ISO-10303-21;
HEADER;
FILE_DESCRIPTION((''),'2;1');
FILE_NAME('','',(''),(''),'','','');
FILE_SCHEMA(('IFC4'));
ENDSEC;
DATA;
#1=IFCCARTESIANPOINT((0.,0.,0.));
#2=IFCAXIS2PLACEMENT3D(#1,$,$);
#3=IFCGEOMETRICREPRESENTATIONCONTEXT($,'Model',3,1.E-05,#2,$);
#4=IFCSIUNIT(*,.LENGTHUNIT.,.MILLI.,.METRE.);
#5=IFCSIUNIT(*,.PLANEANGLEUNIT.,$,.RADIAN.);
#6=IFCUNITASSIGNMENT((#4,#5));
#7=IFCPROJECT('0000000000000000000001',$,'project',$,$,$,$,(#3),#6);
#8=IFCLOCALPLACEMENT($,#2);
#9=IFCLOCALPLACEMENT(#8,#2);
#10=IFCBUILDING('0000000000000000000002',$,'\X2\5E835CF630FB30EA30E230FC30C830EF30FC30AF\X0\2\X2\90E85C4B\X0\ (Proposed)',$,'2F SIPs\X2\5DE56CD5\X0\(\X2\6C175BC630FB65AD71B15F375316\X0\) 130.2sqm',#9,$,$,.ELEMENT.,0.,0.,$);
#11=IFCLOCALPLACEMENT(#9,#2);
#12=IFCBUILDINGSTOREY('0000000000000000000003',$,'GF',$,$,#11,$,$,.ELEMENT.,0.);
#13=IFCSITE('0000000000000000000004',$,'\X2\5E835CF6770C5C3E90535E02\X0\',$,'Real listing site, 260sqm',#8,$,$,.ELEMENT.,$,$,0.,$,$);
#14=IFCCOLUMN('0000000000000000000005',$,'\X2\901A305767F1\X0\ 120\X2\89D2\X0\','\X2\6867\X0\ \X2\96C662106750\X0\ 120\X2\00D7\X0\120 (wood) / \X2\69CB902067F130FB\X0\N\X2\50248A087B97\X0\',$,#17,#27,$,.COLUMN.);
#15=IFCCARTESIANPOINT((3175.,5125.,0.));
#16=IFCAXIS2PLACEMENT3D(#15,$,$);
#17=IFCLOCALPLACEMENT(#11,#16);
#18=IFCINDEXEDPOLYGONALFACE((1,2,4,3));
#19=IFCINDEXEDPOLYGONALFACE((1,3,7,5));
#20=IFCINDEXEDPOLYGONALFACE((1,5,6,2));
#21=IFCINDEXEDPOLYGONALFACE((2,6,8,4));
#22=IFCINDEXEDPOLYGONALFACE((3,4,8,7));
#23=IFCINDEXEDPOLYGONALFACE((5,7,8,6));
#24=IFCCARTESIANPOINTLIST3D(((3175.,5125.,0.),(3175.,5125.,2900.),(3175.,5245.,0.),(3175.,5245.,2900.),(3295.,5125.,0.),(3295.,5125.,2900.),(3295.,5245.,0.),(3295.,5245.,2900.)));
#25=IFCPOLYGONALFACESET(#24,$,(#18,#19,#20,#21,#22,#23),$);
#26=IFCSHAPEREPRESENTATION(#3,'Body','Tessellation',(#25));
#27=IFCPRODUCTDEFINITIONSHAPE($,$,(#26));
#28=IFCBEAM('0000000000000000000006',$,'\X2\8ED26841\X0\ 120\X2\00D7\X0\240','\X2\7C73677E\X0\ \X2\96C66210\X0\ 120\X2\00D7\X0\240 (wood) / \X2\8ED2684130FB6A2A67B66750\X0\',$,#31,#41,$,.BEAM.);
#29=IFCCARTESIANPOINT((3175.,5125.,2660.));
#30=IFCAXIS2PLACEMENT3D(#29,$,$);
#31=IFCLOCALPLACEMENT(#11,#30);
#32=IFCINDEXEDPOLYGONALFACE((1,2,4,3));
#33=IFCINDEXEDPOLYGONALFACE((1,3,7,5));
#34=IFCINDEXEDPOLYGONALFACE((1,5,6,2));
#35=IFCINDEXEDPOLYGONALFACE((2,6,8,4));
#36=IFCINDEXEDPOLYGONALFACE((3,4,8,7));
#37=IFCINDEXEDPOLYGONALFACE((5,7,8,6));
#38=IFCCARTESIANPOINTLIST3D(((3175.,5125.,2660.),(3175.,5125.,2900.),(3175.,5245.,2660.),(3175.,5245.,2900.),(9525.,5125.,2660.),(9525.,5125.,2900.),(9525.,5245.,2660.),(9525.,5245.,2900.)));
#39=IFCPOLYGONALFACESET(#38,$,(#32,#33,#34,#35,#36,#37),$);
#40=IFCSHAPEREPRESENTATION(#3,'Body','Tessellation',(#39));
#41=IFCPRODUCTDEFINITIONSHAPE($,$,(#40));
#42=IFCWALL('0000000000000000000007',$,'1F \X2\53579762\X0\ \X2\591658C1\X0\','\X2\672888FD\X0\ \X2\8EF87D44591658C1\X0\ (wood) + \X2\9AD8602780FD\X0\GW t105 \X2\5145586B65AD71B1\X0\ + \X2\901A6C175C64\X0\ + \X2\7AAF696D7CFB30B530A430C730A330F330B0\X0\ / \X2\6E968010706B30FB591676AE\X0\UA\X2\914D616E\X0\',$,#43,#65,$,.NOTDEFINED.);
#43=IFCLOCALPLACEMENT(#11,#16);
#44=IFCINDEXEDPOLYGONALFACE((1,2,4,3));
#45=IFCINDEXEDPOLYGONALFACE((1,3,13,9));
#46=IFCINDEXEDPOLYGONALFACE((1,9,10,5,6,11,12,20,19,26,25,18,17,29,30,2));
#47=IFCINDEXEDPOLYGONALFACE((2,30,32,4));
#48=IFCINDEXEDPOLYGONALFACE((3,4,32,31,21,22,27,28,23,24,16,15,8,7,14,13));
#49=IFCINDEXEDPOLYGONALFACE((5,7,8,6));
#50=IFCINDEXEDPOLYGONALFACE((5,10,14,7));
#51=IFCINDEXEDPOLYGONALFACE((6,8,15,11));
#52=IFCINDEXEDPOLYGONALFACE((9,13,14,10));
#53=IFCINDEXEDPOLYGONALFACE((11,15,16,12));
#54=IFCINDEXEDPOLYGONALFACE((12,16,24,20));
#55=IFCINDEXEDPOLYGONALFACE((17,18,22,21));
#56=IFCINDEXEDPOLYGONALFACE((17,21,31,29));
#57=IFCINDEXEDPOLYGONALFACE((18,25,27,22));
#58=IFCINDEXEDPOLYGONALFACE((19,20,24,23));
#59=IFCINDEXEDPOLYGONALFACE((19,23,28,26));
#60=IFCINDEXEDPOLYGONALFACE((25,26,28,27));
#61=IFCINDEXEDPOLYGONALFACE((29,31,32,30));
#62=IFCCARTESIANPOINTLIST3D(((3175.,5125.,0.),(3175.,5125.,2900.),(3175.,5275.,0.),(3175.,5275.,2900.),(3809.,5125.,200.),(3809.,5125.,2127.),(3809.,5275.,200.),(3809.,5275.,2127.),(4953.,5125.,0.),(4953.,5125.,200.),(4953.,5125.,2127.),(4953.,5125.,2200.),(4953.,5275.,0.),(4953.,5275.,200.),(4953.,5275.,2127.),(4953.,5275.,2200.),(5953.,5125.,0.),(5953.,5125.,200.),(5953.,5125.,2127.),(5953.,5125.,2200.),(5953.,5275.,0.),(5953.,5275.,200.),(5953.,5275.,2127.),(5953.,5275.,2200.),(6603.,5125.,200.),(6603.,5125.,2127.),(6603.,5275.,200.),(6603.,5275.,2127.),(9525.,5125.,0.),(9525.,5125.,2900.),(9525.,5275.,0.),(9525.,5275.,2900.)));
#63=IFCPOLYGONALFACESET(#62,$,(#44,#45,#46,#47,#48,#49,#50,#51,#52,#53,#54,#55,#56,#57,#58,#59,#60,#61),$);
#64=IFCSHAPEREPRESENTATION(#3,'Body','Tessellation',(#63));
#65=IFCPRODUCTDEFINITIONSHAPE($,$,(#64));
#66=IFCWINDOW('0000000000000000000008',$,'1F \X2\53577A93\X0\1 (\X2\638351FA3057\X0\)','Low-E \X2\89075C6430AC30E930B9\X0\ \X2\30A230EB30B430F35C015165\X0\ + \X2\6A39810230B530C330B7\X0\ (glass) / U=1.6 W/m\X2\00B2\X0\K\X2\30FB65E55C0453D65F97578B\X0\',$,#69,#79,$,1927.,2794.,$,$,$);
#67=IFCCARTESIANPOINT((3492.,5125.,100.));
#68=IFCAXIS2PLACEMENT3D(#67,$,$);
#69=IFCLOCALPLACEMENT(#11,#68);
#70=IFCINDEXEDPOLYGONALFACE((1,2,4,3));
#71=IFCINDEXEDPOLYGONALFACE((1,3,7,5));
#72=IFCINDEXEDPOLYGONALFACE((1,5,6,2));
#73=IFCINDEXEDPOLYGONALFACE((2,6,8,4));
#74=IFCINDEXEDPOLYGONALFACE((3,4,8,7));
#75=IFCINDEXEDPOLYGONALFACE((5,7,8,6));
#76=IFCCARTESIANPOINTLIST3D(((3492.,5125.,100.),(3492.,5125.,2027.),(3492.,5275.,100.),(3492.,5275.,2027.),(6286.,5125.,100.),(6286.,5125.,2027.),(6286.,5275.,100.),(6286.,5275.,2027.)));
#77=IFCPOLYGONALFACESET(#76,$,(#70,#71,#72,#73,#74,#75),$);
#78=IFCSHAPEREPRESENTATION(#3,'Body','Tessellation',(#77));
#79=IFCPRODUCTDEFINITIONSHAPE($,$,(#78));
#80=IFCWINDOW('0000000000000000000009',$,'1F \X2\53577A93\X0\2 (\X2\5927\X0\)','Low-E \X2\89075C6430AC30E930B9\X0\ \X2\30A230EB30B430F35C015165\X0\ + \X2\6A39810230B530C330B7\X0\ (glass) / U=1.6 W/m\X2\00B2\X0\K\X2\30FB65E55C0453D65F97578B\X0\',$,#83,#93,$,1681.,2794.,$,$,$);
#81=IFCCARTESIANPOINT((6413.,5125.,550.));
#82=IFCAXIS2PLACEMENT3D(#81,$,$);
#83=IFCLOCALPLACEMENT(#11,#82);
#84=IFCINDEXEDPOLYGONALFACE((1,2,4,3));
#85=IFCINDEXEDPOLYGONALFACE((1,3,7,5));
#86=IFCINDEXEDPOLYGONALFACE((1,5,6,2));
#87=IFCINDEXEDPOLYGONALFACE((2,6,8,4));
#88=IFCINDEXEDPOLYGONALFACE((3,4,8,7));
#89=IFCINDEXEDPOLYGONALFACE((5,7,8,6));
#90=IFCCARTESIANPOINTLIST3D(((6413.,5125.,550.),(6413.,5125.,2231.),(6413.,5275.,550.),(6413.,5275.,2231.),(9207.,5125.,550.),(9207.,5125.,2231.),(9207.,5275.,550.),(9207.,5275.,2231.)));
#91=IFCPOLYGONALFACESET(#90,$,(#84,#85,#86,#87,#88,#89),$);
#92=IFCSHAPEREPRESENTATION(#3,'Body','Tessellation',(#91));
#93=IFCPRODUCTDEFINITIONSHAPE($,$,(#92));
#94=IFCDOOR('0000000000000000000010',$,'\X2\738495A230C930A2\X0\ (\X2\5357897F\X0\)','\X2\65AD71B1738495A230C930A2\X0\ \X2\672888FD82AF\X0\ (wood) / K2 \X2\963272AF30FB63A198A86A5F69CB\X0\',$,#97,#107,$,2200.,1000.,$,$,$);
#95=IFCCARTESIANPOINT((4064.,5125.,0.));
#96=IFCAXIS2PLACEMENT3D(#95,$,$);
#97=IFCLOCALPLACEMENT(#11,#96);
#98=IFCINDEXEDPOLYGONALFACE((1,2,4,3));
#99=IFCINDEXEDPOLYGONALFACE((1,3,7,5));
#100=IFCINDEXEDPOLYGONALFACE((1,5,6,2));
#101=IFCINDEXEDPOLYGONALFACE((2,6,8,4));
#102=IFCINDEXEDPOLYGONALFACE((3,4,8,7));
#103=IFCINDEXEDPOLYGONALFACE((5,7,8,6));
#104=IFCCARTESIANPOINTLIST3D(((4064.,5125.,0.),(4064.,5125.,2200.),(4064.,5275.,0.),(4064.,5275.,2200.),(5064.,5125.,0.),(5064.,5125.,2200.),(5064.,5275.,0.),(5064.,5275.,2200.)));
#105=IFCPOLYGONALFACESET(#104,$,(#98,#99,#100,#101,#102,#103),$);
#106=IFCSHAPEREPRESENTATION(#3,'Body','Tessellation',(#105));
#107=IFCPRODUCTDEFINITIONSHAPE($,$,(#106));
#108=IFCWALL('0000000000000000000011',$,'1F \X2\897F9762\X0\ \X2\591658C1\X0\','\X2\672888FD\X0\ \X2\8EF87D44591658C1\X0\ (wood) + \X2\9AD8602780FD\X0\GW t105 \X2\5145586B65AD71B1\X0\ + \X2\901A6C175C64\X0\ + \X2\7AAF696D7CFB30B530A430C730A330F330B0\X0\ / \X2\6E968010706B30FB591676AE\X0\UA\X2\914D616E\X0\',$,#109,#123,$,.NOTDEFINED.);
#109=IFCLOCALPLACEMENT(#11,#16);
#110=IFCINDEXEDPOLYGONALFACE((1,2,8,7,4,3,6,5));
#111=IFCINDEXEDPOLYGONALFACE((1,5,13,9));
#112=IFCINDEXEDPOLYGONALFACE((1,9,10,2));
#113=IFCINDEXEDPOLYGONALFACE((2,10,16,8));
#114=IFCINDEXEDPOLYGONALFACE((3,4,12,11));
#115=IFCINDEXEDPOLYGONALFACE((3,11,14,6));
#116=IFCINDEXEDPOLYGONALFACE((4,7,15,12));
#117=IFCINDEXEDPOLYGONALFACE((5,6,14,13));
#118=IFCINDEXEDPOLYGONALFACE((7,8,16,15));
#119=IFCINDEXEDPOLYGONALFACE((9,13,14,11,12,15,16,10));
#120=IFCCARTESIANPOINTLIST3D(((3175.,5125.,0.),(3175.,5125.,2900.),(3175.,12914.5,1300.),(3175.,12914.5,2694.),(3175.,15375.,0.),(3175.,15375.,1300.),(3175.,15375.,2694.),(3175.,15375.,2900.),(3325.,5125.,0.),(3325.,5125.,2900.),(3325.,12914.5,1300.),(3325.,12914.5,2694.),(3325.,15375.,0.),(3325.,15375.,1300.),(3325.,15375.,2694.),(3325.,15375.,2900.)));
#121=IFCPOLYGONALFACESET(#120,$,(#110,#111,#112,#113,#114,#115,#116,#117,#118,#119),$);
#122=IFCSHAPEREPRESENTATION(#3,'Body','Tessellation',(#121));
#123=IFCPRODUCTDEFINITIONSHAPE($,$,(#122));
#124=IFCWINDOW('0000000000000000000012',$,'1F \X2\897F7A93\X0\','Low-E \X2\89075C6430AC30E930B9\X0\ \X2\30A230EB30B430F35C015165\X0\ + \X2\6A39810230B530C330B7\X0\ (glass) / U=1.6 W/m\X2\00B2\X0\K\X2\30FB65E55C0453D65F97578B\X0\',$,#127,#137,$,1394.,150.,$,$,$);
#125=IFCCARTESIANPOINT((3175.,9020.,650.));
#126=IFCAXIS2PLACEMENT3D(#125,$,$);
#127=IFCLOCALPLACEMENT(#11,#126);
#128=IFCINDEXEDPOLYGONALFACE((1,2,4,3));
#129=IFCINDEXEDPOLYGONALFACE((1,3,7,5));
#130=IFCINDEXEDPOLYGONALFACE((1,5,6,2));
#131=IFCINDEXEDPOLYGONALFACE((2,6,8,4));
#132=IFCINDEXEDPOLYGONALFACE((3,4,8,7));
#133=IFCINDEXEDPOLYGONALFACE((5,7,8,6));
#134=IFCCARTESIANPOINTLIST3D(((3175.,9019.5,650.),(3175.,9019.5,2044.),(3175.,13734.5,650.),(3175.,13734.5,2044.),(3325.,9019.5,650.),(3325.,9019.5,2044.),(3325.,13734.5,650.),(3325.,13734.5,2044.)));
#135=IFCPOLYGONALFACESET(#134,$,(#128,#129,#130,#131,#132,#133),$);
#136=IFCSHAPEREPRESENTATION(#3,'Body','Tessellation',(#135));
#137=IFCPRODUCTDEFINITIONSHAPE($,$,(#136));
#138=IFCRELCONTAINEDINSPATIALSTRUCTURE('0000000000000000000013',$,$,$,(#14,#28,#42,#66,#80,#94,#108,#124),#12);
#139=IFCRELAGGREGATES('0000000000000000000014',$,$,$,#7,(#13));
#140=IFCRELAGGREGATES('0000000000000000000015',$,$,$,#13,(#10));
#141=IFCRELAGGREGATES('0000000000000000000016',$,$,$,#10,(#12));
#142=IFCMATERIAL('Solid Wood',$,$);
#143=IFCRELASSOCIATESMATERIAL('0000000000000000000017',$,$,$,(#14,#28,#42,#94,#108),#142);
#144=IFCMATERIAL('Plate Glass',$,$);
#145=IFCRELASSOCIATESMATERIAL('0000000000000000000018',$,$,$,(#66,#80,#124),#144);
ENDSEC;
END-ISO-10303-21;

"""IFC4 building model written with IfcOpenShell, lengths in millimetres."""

from ifc_helpers import new_model, si_unit, frame, frame_2d, origin, place, context, project, spatial, rectangle, extrude, material, element, fill, save


model = new_model("IFC4")

# Units and contexts
model_context = context("Model", 3, precision=1e-05, world=origin())
ifc_project = project(units=[si_unit("LENGTHUNIT", "METRE", prefix="MILLI"), si_unit("PLANEANGLEUNIT", "RADIAN")], contexts=[model_context])

# Site, building, storey
site_placement = place(None, origin())
site = spatial("IfcSite", under=ifc_project, at=site_placement, Name="広島県尾道市", ObjectType="Real listing site, 260sqm", CompositionType="ELEMENT", RefElevation=0.0)
building_placement = place(site_placement, origin())
building = spatial("IfcBuilding", under=site, at=building_placement, Name="広島・リモートワーク2部屋 (Proposed)", ObjectType="2F SIPs工法(気密・断熱強化) 130.2sqm", CompositionType="ELEMENT", ElevationOfRefHeight=0.0, ElevationOfTerrain=0.0)
storey_placement = place(building_placement, origin())
storey = spatial("IfcBuildingStorey", under=building, at=storey_placement, Name="GF", CompositionType="ELEMENT", Elevation=0.0)

# Column
ifc_material_1 = material(Name="Solid Wood")
column_placement = place(storey_placement, frame((3175.0, 5125.0, 0.0)))
element("IfcColumn", 1, at=column_placement, inside=storey, material=ifc_material_1, Name="通し柱 120角", Description="桧 集成材 120×120 (wood) / 構造柱・N値計算", PredefinedType="COLUMN", context=model_context, shape_type="SweptSolid", body=[
    extrude(rectangle(XDim=120.0, YDim=120.0, at=frame_2d((60.0, 60.0))), frame((3175.0, 5125.0, 0.0)), (0.0, 0.0, 1.0), 2900.0),
])

# Beam
beam_1_placement = place(storey_placement, frame((3175.0, 5125.0, 2660.0)))
element("IfcBeam", 2, at=beam_1_placement, inside=storey, material=ifc_material_1, Name="軒桁 120×240", Description="米松 集成 120×240 (wood) / 軒桁・横架材", PredefinedType="BEAM", context=model_context, shape_type="SweptSolid", body=[
    extrude(rectangle(XDim=6350.0, YDim=120.0, at=frame_2d((3175.0, 60.0))), frame((3175.0, 5125.0, 2660.0)), (0.0, 0.0, 1.0), 240.0),
])

# Wall, openings, windows, door
wall_1_placement = place(storey_placement, frame((3175.0, 5125.0, 0.0)))
wall_1 = element("IfcWall", 3, at=wall_1_placement, inside=storey, material=ifc_material_1, Name="1F 南面 外壁", Description="木製 軸組外壁 (wood) + 高性能GW t105 充填断熱 + 通気層 + 窯業系サイディング / 準耐火・外皮UA配慮", PredefinedType="NOTDEFINED", context=model_context, shape_type="SweptSolid", body=[
    extrude(rectangle(XDim=6350.0, YDim=150.0, at=frame_2d((3175.0, 75.0))), frame((3175.0, 5125.0, 0.0)), (0.0, 0.0, 1.0), 2900.0),
])
opening_1_placement = place(storey_placement, frame((3492.0, 5125.0, 100.0)))
opening_1 = element("IfcOpeningElement", 4, at=opening_1_placement, cuts=wall_1, PredefinedType="NOTDEFINED", context=model_context, shape_type="SweptSolid", body=[
    extrude(rectangle(XDim=2794.0, YDim=150.0, at=frame_2d((1397.0, 75.0))), frame((3492.0, 5125.0, 100.0)), (0.0, 0.0, 1.0), 1927.0),
])
opening_2_placement = place(storey_placement, frame((6413.0, 5125.0, 550.0)))
opening_2 = element("IfcOpeningElement", 5, at=opening_2_placement, cuts=wall_1, PredefinedType="NOTDEFINED", context=model_context, shape_type="SweptSolid", body=[
    extrude(rectangle(XDim=2794.0, YDim=150.0, at=frame_2d((1397.0, 75.0))), frame((6413.0, 5125.0, 550.0)), (0.0, 0.0, 1.0), 1681.0),
])
opening_3_placement = place(storey_placement, frame((4064.0, 5125.0, 0.0)))
opening_3 = element("IfcOpeningElement", 6, at=opening_3_placement, cuts=wall_1, PredefinedType="NOTDEFINED", context=model_context, shape_type="SweptSolid", body=[
    extrude(rectangle(XDim=1000.0, YDim=150.0, at=frame_2d((500.0, 75.0))), frame((4064.0, 5125.0, 0.0)), (0.0, 0.0, 1.0), 2200.0),
])
ifc_material_2 = material(Name="Plate Glass")
window_1_placement = place(storey_placement, frame((3492.0, 5125.0, 100.0)))
window_1 = element("IfcWindow", 7, at=window_1_placement, inside=storey, material=ifc_material_2, Name="1F 南窓1 (掃出し)", Description="Low-E 複層ガラス アルゴン封入 + 樹脂サッシ (glass) / U=1.6 W/m²K・日射取得型", OverallHeight=1927.0, OverallWidth=2794.0, context=model_context, shape_type="SweptSolid", body=[
    extrude(rectangle(XDim=2794.0, YDim=150.0, at=frame_2d((1397.0, 75.0))), frame((3492.0, 5125.0, 100.0)), (0.0, 0.0, 1.0), 1927.0),
])
fill(opening_1, window_1)
window_2_placement = place(storey_placement, frame((6413.0, 5125.0, 550.0)))
window_2 = element("IfcWindow", 8, at=window_2_placement, inside=storey, material=ifc_material_2, Name="1F 南窓2 (大)", Description="Low-E 複層ガラス アルゴン封入 + 樹脂サッシ (glass) / U=1.6 W/m²K・日射取得型", OverallHeight=1681.0, OverallWidth=2794.0, context=model_context, shape_type="SweptSolid", body=[
    extrude(rectangle(XDim=2794.0, YDim=150.0, at=frame_2d((1397.0, 75.0))), frame((6413.0, 5125.0, 550.0)), (0.0, 0.0, 1.0), 1681.0),
])
fill(opening_2, window_2)
door_placement = place(storey_placement, frame((4064.0, 5125.0, 0.0)))
door = element("IfcDoor", 9, at=door_placement, inside=storey, material=ifc_material_1, Name="玄関ドア (南西)", Description="断熱玄関ドア 木製芯 (wood) / K2 防犯・採風機構", OverallHeight=2200.0, OverallWidth=1000.0, context=model_context, shape_type="SweptSolid", body=[
    extrude(rectangle(XDim=1000.0, YDim=150.0, at=frame_2d((500.0, 75.0))), frame((4064.0, 5125.0, 0.0)), (0.0, 0.0, 1.0), 2200.0),
])
fill(opening_3, door)

# Wall, opening, window
wall_2_placement = place(storey_placement, frame((3175.0, 5125.0, 0.0)))
wall_2 = element("IfcWall", 10, at=wall_2_placement, inside=storey, material=ifc_material_1, Name="1F 西面 外壁", Description="木製 軸組外壁 (wood) + 高性能GW t105 充填断熱 + 通気層 + 窯業系サイディング / 準耐火・外皮UA配慮", PredefinedType="NOTDEFINED", context=model_context, shape_type="SweptSolid", body=[
    extrude(rectangle(XDim=150.0, YDim=10250.0, at=frame_2d((75.0, 5125.0))), frame((3175.0, 5125.0, 0.0)), (0.0, 0.0, 1.0), 2900.0),
])
opening_4_placement = place(storey_placement, frame((3175.0, 9020.0, 650.0)))
opening_4 = element("IfcOpeningElement", 11, at=opening_4_placement, cuts=wall_2, PredefinedType="NOTDEFINED", context=model_context, shape_type="SweptSolid", body=[
    extrude(rectangle(XDim=150.0, YDim=4715.0, at=frame_2d((75.0, 2357.0))), frame((3175.0, 9020.0, 650.0)), (0.0, 0.0, 1.0), 1394.0),
])
window_3_placement = place(storey_placement, frame((3175.0, 9020.0, 650.0)))
window_3 = element("IfcWindow", 12, at=window_3_placement, inside=storey, material=ifc_material_2, Name="1F 西窓", Description="Low-E 複層ガラス アルゴン封入 + 樹脂サッシ (glass) / U=1.6 W/m²K・日射取得型", OverallHeight=1394.0, OverallWidth=150.0, context=model_context, shape_type="SweptSolid", body=[
    extrude(rectangle(XDim=150.0, YDim=4715.0, at=frame_2d((75.0, 2357.0))), frame((3175.0, 9020.0, 650.0)), (0.0, 0.0, 1.0), 1394.0),
])
fill(opening_4, window_3)

save(model, "model.ifc")
